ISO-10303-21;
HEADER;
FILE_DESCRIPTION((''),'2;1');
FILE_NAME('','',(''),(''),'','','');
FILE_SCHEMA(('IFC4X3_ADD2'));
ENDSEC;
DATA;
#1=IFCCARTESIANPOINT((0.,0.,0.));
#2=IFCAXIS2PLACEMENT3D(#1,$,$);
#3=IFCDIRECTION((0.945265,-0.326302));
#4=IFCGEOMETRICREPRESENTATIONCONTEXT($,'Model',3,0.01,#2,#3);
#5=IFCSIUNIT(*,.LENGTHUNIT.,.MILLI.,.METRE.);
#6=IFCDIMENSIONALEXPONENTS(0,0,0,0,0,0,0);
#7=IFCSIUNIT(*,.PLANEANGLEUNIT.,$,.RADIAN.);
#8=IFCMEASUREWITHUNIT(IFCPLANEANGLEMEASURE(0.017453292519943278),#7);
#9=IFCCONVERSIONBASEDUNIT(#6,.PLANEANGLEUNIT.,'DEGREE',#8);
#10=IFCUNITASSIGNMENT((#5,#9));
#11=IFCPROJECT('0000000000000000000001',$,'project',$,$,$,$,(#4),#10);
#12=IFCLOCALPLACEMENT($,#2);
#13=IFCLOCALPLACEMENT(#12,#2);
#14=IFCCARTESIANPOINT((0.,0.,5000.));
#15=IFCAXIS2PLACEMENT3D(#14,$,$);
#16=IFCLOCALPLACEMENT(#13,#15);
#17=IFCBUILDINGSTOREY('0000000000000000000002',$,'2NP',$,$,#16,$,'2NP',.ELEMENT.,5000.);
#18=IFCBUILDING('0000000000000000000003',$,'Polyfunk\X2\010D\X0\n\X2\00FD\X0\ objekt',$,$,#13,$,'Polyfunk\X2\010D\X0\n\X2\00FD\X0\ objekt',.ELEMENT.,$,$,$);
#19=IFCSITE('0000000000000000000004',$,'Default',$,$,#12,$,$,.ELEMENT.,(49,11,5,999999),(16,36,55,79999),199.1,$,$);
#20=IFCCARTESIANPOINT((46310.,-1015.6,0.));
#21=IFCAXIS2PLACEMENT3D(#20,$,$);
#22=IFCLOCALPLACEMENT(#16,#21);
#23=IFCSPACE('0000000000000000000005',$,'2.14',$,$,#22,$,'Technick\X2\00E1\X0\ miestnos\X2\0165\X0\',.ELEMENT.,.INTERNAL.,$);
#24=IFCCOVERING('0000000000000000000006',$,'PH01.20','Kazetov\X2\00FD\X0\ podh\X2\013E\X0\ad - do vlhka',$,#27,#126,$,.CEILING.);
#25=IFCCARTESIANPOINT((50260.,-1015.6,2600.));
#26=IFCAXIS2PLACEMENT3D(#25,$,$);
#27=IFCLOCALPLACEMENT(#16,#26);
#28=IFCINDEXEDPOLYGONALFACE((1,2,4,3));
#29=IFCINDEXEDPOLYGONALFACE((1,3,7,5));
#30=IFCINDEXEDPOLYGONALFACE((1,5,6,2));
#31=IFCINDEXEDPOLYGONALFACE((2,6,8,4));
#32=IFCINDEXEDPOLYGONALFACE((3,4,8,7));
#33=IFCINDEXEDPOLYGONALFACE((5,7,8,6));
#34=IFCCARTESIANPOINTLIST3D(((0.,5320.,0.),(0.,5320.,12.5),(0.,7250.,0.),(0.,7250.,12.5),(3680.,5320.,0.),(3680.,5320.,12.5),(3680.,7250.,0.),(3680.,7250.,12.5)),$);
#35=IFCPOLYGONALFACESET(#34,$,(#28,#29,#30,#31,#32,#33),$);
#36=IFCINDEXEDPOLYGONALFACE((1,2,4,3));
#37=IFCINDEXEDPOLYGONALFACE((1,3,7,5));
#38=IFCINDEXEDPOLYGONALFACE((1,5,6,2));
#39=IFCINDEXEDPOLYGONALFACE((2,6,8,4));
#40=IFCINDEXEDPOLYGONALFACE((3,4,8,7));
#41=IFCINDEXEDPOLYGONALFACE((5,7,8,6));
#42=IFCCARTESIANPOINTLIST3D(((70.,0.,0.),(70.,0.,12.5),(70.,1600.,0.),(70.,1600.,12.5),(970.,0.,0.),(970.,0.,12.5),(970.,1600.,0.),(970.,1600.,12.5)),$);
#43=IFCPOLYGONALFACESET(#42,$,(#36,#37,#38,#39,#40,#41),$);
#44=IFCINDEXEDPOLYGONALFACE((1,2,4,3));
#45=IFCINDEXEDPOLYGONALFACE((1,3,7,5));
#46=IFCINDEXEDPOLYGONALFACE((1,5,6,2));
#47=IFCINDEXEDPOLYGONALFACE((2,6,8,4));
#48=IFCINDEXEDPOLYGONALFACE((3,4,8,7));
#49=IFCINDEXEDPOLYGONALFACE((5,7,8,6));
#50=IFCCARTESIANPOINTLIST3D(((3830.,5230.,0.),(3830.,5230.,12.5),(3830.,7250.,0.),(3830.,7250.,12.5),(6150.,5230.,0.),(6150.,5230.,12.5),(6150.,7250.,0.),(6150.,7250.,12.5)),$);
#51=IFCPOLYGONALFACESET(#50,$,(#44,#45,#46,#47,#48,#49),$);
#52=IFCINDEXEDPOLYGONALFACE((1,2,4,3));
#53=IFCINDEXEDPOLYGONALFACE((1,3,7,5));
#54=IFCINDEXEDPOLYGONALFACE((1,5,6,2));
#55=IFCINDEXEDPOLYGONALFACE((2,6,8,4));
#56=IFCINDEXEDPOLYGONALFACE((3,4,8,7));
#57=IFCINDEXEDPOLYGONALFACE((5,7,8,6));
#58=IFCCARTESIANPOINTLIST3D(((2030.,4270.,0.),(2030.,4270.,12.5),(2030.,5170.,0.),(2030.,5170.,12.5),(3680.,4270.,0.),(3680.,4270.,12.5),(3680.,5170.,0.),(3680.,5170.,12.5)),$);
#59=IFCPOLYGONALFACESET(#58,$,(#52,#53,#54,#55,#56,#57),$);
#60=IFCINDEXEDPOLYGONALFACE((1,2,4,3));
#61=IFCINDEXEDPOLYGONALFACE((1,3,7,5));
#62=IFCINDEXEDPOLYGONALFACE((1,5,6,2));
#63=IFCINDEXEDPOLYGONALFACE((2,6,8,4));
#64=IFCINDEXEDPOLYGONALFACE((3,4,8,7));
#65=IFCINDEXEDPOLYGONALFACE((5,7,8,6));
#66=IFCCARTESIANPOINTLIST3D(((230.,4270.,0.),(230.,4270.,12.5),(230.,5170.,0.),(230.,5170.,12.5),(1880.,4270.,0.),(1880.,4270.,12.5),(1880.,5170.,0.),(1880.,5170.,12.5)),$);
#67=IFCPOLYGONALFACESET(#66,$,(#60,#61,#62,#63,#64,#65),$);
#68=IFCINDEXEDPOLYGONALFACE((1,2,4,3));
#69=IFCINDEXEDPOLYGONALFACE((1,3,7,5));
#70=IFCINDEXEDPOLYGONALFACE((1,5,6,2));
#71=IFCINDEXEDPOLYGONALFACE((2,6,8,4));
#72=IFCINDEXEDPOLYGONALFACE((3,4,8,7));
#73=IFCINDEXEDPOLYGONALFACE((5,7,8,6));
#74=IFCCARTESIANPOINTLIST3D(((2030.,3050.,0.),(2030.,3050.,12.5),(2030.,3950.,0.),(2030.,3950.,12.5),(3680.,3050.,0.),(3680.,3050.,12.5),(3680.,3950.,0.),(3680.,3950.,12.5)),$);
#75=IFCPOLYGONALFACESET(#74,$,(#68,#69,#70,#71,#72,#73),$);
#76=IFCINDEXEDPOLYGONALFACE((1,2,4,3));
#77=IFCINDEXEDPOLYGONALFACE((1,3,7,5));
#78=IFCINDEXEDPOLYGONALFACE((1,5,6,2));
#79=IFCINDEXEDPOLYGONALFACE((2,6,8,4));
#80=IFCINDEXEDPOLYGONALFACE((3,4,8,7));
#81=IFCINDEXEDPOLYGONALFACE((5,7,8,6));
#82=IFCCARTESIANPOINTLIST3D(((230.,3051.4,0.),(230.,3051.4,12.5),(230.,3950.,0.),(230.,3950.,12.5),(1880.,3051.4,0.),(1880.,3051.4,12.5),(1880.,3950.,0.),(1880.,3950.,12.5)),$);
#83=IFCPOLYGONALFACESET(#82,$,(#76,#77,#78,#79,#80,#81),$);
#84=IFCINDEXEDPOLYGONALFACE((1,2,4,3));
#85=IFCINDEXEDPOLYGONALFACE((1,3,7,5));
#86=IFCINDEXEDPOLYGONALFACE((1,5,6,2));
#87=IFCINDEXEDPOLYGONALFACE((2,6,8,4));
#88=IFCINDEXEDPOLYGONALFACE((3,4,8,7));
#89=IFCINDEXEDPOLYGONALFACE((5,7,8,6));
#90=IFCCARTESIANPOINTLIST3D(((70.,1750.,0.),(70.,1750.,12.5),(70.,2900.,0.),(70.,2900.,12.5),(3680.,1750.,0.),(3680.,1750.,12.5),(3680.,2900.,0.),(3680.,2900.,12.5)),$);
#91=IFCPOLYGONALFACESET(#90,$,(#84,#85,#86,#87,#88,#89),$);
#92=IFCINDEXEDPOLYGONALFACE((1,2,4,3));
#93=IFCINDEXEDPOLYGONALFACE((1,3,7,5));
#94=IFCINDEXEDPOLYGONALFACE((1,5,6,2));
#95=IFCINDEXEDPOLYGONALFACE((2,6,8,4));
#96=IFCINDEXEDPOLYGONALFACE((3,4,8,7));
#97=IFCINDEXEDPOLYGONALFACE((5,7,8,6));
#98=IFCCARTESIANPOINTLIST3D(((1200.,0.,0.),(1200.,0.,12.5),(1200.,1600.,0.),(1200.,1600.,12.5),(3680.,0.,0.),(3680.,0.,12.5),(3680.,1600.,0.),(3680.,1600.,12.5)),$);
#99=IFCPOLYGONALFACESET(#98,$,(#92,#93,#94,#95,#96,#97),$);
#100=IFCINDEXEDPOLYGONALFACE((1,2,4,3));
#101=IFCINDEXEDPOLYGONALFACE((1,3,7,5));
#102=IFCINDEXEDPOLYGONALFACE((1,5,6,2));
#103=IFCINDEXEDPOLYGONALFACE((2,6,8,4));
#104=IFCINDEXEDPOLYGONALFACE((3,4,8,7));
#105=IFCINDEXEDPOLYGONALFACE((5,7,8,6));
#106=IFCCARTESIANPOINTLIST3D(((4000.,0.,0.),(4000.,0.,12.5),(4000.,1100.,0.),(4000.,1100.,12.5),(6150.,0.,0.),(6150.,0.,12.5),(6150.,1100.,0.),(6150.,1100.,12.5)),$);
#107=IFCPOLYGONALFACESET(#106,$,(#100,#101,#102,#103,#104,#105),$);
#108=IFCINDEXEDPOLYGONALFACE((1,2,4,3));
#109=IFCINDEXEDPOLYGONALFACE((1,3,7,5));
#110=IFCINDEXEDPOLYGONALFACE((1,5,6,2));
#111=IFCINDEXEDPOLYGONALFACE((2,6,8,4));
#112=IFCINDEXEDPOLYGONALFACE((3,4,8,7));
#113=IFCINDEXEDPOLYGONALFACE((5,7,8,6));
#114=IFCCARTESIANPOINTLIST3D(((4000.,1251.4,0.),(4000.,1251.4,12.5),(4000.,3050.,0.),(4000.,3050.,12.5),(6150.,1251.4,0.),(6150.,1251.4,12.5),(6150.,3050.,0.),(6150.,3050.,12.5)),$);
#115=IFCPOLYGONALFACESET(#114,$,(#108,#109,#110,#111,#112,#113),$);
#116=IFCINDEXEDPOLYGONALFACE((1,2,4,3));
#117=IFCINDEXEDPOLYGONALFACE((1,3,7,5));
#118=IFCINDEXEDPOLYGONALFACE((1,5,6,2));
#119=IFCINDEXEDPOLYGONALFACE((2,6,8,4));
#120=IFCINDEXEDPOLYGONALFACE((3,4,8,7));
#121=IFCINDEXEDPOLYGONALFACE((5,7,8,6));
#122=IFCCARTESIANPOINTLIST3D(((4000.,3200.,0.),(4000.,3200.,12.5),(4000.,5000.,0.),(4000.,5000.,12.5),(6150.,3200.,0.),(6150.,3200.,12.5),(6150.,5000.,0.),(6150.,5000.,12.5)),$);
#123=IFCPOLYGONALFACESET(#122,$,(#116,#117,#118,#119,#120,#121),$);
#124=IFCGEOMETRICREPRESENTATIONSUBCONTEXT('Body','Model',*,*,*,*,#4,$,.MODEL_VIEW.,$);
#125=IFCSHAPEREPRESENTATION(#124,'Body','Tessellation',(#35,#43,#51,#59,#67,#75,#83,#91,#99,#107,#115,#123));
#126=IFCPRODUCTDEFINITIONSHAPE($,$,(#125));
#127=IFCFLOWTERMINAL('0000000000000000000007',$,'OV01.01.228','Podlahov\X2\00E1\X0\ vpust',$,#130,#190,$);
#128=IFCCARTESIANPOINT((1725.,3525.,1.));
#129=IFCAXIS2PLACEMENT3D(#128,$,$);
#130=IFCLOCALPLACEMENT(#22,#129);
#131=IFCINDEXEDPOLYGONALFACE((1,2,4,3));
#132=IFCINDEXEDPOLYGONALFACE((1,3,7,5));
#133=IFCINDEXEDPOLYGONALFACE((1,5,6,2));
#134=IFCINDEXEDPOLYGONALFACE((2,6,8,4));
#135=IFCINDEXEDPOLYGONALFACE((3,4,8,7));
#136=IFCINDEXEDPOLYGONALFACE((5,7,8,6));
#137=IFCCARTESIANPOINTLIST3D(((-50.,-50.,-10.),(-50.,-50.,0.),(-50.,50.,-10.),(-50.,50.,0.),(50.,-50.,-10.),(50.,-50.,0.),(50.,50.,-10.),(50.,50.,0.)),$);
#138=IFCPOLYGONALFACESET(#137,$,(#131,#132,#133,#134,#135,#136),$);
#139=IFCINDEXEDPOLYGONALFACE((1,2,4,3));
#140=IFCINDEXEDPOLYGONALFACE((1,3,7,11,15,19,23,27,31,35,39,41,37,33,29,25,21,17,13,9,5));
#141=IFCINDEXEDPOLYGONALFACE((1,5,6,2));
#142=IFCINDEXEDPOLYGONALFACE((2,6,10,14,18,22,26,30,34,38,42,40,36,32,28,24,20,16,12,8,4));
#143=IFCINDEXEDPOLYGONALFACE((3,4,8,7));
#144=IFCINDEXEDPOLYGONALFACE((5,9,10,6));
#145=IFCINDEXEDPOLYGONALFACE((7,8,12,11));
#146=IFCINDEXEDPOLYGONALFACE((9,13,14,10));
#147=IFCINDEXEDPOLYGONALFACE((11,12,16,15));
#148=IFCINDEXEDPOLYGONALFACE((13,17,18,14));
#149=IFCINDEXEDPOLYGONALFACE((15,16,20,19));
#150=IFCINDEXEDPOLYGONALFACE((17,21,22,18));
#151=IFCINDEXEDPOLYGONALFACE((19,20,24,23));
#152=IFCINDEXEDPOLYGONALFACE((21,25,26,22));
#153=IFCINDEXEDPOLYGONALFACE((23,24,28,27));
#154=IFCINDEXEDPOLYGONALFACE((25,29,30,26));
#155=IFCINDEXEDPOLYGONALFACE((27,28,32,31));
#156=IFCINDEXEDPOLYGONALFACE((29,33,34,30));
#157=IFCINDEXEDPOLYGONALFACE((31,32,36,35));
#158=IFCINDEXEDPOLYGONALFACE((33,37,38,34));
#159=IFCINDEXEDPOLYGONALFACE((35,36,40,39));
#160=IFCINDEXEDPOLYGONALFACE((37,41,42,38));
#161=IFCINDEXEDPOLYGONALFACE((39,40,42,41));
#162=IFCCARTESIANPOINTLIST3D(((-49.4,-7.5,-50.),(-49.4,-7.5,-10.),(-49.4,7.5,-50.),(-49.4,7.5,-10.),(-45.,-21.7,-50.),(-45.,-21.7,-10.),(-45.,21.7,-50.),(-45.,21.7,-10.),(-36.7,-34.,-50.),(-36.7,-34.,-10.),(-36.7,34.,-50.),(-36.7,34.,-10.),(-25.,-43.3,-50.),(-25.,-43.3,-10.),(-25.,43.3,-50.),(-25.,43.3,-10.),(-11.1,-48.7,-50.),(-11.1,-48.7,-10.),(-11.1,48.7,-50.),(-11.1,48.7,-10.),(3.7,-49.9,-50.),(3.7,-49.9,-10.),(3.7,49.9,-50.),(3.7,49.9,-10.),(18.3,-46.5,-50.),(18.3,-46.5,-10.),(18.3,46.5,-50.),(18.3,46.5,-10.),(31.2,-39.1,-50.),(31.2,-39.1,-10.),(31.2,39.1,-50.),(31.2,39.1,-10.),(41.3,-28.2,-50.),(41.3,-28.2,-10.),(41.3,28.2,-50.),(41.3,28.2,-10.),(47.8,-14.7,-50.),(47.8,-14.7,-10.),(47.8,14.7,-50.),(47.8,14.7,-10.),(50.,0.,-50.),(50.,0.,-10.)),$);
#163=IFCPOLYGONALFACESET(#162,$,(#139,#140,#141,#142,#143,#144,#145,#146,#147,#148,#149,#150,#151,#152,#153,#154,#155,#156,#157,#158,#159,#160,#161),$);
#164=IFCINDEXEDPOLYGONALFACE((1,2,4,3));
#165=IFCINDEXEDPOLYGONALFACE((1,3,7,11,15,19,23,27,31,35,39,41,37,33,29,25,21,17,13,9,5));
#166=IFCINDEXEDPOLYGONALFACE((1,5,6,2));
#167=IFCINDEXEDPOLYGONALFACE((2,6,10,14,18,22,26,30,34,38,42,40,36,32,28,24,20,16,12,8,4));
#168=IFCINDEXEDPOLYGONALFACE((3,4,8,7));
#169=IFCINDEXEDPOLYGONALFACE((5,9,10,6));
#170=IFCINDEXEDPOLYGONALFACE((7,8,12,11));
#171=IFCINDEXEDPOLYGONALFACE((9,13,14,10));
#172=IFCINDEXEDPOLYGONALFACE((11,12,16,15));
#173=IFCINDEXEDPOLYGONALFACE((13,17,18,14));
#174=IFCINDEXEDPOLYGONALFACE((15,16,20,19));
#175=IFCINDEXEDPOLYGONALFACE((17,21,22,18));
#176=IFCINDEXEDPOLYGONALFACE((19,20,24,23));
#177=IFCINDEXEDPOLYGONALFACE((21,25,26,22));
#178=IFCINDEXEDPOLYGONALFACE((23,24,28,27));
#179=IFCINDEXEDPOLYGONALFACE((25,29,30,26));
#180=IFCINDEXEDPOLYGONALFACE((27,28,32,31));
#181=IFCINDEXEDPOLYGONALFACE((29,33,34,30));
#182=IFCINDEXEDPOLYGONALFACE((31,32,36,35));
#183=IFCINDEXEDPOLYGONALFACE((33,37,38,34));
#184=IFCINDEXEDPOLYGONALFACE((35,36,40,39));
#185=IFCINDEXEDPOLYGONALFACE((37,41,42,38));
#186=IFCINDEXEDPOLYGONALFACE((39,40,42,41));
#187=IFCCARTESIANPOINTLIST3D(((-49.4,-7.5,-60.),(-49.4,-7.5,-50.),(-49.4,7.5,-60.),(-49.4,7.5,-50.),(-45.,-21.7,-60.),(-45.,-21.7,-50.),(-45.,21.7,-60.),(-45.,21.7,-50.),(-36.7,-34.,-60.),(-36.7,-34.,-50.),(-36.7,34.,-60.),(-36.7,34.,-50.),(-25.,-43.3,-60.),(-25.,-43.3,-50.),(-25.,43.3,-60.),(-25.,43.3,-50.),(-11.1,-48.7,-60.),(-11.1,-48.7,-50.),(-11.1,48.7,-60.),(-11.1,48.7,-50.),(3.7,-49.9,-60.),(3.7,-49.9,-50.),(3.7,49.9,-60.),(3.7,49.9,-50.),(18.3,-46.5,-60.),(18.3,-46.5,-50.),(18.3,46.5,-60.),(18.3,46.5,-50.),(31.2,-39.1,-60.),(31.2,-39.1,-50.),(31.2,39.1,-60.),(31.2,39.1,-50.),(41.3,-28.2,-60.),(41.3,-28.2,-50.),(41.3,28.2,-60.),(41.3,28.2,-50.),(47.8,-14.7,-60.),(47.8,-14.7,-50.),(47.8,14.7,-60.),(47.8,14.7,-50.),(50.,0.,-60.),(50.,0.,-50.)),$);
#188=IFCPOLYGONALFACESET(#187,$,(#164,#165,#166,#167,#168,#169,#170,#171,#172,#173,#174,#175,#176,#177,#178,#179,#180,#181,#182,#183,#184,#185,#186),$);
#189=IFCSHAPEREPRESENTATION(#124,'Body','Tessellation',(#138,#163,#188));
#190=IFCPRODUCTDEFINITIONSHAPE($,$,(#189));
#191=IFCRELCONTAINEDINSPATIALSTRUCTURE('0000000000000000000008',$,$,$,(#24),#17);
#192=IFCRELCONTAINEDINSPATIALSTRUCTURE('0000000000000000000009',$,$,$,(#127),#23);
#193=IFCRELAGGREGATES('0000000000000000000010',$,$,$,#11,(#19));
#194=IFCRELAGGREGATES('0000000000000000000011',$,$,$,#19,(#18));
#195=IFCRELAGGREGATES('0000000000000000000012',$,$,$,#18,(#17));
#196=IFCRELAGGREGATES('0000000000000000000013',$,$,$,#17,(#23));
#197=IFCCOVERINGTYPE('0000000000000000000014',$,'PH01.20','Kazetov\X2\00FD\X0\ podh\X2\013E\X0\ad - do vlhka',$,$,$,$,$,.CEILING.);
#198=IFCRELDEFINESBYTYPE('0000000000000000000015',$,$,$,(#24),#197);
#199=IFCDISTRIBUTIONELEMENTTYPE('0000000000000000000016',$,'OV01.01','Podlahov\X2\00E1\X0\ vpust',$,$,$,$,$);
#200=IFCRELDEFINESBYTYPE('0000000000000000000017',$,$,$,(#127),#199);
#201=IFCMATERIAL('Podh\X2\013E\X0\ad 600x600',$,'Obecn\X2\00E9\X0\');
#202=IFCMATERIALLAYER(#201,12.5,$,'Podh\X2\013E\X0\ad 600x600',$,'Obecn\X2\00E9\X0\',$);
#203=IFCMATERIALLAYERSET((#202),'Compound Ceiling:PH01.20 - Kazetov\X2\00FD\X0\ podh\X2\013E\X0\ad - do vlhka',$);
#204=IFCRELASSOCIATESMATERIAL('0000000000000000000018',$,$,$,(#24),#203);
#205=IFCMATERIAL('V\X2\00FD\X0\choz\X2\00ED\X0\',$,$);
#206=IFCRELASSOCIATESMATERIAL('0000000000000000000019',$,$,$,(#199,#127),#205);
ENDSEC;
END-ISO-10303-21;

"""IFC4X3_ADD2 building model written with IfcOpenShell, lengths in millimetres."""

from ifc_helpers import new_model, entity, si_unit, converted_unit, direction, frame, frame_2d, origin, origin_2d_with_axis, place, context, subcontext, project, spatial, rectangle, circle, extrude, source, transform, mapped, material, layer, layer_set, layer_usage, type_object, type_shapes, element, save


model = new_model("IFC4X3_ADD2")

# Units and contexts
model_context = context("Model", 3, precision=0.01, world=origin(), true_north=direction((0.945265, -0.326302)))
body_context = subcontext(model_context, "Body", "Model", "MODEL_VIEW")
ifc_project = project(units=[si_unit("LENGTHUNIT", "METRE", prefix="MILLI"), converted_unit("PLANEANGLEUNIT", "DEGREE", entity("IfcPlaneAngleMeasure", 0.017453292519943278), si_unit("PLANEANGLEUNIT", "RADIAN"), dimensions=[0, 0, 0, 0, 0, 0, 0])], contexts=[model_context])

# Site, building, storey
site_placement = place(None, origin())
site = spatial("IfcSite", under=ifc_project, at=site_placement, Name="Default", CompositionType="ELEMENT", RefLatitude=(49, 11, 5, 999999), RefLongitude=(16, 36, 55, 79999), RefElevation=199.1)
building_placement = place(site_placement, origin())
building = spatial("IfcBuilding", under=site, at=building_placement, Name="Polyfunkčný objekt", LongName="Polyfunkčný objekt", CompositionType="ELEMENT")
storey_placement = place(building_placement, frame((0.0, 0.0, 5000.0)))
storey = spatial("IfcBuildingStorey", under=building, at=storey_placement, Name="2NP", LongName="2NP", CompositionType="ELEMENT", Elevation=5000.0)

# Covering
ifc_material_1 = material(Name="Podhľad 600x600", Category="Obecné")
ifc_layer_1 = layer(ifc_material_1, 12.5, Name="Podhľad 600x600", Category="Obecné")
ifc_layer_set_1 = layer_set([ifc_layer_1], Name="Compound Ceiling:PH01.20 - Kazetový podhľad - do vlhka")
ifc_layer_usage_1 = layer_usage(ifc_layer_set_1, "AXIS3", "NEGATIVE", 0.0)
covering_type = type_object("IfcCoveringType", Name="PH01.20", Description="Kazetový podhľad - do vlhka", PredefinedType="CEILING")
covering_placement = place(storey_placement, frame((50260.0, -1015.6, 2600.0)))
element("IfcCovering", 1, at=covering_placement, inside=storey, type_object=covering_type, material=ifc_layer_usage_1, Name="PH01.20", Description="Kazetový podhľad - do vlhka", PredefinedType="CEILING", context=body_context, shape_type="SweptSolid", body=[
    extrude(rectangle(XDim=1930.0, YDim=3680.0, at=frame_2d((0.0, 0.0), x_axis=(1.0, 0.0))), frame((1840.0, 6285.0, 0.0), z_axis=(0.0, 0.0, 1.0), x_axis=(0.0, -1.0, 0.0)), (0.0, 0.0, 1.0), 12.5),
    extrude(rectangle(XDim=1600.0, YDim=900.0, at=origin_2d_with_axis()), frame((520.0, 800.0, 0.0), z_axis=(0.0, 0.0, 1.0), x_axis=(0.0, 1.0, 0.0)), (0.0, 0.0, 1.0), 12.5),
    extrude(rectangle(XDim=2320.0, YDim=2020.0, at=frame_2d((0.0, 0.0), x_axis=(1.0, 0.0))), frame((4990.0, 6240.0, 0.0), z_axis=(0.0, 0.0, 1.0), x_axis=(-1.0, 0.0, 0.0)), (0.0, 0.0, 1.0), 12.5),
    extrude(rectangle(XDim=900.0, YDim=1650.0, at=frame_2d((0.0, 0.0), x_axis=(1.0, 0.0))), frame((2855.0, 4720.0, 0.0), z_axis=(0.0, 0.0, 1.0), x_axis=(0.0, 1.0, 0.0)), (0.0, 0.0, 1.0), 12.5),
    extrude(rectangle(XDim=1650.0, YDim=900.0, at=frame_2d((0.0, 0.0), x_axis=(1.0, 0.0))), frame((1055.0, 4720.0, 0.0), z_axis=(0.0, 0.0, 1.0), x_axis=(-1.0, 0.0, 0.0)), (0.0, 0.0, 1.0), 12.5),
    extrude(rectangle(XDim=900.0, YDim=1650.0, at=frame_2d((0.0, 0.0), x_axis=(1.0, 0.0))), frame((2855.0, 3500.0, 0.0), z_axis=(0.0, 0.0, 1.0), x_axis=(0.0, -1.0, 0.0)), (0.0, 0.0, 1.0), 12.5),
    extrude(rectangle(XDim=1650.0, YDim=898.6, at=frame_2d((0.0, 0.0), x_axis=(1.0, 0.0))), frame((1055.0, 3500.7, 0.0), z_axis=(0.0, 0.0, 1.0), x_axis=(-1.0, 0.0, 0.0)), (0.0, 0.0, 1.0), 12.5),
    extrude(rectangle(XDim=3610.0, YDim=1150.0, at=frame_2d((0.0, 0.0), x_axis=(1.0, 0.0))), frame((1875.0, 2325.0, 0.0), z_axis=(0.0, 0.0, 1.0), x_axis=(-1.0, 0.0, 0.0)), (0.0, 0.0, 1.0), 12.5),
    extrude(rectangle(XDim=2480.0, YDim=1600.0, at=origin_2d_with_axis()), frame((2440.0, 800.0, 0.0), z_axis=(0.0, 0.0, 1.0), x_axis=(-1.0, 0.0, 0.0)), (0.0, 0.0, 1.0), 12.5),
    extrude(rectangle(XDim=1100.0, YDim=2150.0, at=frame_2d((0.0, 0.0), x_axis=(1.0, 0.0))), frame((5075.0, 550.0, 0.0), z_axis=(0.0, 0.0, 1.0), x_axis=(0.0, 1.0, 0.0)), (0.0, 0.0, 1.0), 12.5),
    extrude(rectangle(XDim=1798.6, YDim=2150.0, at=origin_2d_with_axis()), frame((5075.0, 2150.7, 0.0), z_axis=(0.0, 0.0, 1.0), x_axis=(0.0, 1.0, 0.0)), (0.0, 0.0, 1.0), 12.5),
    extrude(rectangle(XDim=1800.0, YDim=2150.0, at=frame_2d((0.0, 0.0), x_axis=(1.0, 0.0))), frame((5075.0, 4100.0, 0.0), z_axis=(0.0, 0.0, 1.0), x_axis=(0.0, 1.0, 0.0)), (0.0, 0.0, 1.0), 12.5),
])

# Shared definitions
space_placement = place(storey_placement, frame((46310.0, -1015.6, 0.0)))
space = spatial("IfcSpace", under=storey, at=space_placement, Name="2.14", LongName="Technická miestnosť", CompositionType="ELEMENT", PredefinedType="INTERNAL")

# Flow terminal
ifc_material_2 = material(Name="Výchozí")
distribution_element_type = type_object("IfcDistributionElementType", Name="OV01.01", Description="Podlahová vpust", material=ifc_material_2)
shared_shape_1 = source(origin(), body_context, "Body", "SweptSolid", [
    extrude(rectangle(XDim=100.0, YDim=100.0, at=frame_2d((0.0, 0.0), x_axis=(1.0, 0.0))), frame((0.0, 0.0, -10.0), z_axis=(0.0, 0.0, 1.0), x_axis=(-1.0, 0.0, 0.0)), (0.0, 0.0, 1.0), 10.0),
    extrude(circle(Radius=50.0, at=frame_2d((0.0, 0.0), x_axis=(1.0, 0.0))), frame((0.0, 0.0, -50.0)), (0.0, 0.0, 1.0), 40.0),
    extrude(circle(Radius=50.0, at=frame_2d((0.0, 0.0), x_axis=(1.0, 0.0))), frame((0.0, 0.0, -60.0)), (0.0, 0.0, 1.0), 10.0),
])
type_shapes(distribution_element_type, [shared_shape_1])
flow_terminal_placement = place(space_placement, frame((1725.0, 3525.0, 1.0)))
element("IfcFlowTerminal", 2, at=flow_terminal_placement, inside=space, type_object=distribution_element_type, material=ifc_material_2, Name="OV01.01.228", Description="Podlahová vpust", context=body_context, shape_type="MappedRepresentation", body=[
    mapped(shared_shape_1, transform((0.0, 0.0, 0.0), scale=1.0)),
])

save(model, "model.ifc")
